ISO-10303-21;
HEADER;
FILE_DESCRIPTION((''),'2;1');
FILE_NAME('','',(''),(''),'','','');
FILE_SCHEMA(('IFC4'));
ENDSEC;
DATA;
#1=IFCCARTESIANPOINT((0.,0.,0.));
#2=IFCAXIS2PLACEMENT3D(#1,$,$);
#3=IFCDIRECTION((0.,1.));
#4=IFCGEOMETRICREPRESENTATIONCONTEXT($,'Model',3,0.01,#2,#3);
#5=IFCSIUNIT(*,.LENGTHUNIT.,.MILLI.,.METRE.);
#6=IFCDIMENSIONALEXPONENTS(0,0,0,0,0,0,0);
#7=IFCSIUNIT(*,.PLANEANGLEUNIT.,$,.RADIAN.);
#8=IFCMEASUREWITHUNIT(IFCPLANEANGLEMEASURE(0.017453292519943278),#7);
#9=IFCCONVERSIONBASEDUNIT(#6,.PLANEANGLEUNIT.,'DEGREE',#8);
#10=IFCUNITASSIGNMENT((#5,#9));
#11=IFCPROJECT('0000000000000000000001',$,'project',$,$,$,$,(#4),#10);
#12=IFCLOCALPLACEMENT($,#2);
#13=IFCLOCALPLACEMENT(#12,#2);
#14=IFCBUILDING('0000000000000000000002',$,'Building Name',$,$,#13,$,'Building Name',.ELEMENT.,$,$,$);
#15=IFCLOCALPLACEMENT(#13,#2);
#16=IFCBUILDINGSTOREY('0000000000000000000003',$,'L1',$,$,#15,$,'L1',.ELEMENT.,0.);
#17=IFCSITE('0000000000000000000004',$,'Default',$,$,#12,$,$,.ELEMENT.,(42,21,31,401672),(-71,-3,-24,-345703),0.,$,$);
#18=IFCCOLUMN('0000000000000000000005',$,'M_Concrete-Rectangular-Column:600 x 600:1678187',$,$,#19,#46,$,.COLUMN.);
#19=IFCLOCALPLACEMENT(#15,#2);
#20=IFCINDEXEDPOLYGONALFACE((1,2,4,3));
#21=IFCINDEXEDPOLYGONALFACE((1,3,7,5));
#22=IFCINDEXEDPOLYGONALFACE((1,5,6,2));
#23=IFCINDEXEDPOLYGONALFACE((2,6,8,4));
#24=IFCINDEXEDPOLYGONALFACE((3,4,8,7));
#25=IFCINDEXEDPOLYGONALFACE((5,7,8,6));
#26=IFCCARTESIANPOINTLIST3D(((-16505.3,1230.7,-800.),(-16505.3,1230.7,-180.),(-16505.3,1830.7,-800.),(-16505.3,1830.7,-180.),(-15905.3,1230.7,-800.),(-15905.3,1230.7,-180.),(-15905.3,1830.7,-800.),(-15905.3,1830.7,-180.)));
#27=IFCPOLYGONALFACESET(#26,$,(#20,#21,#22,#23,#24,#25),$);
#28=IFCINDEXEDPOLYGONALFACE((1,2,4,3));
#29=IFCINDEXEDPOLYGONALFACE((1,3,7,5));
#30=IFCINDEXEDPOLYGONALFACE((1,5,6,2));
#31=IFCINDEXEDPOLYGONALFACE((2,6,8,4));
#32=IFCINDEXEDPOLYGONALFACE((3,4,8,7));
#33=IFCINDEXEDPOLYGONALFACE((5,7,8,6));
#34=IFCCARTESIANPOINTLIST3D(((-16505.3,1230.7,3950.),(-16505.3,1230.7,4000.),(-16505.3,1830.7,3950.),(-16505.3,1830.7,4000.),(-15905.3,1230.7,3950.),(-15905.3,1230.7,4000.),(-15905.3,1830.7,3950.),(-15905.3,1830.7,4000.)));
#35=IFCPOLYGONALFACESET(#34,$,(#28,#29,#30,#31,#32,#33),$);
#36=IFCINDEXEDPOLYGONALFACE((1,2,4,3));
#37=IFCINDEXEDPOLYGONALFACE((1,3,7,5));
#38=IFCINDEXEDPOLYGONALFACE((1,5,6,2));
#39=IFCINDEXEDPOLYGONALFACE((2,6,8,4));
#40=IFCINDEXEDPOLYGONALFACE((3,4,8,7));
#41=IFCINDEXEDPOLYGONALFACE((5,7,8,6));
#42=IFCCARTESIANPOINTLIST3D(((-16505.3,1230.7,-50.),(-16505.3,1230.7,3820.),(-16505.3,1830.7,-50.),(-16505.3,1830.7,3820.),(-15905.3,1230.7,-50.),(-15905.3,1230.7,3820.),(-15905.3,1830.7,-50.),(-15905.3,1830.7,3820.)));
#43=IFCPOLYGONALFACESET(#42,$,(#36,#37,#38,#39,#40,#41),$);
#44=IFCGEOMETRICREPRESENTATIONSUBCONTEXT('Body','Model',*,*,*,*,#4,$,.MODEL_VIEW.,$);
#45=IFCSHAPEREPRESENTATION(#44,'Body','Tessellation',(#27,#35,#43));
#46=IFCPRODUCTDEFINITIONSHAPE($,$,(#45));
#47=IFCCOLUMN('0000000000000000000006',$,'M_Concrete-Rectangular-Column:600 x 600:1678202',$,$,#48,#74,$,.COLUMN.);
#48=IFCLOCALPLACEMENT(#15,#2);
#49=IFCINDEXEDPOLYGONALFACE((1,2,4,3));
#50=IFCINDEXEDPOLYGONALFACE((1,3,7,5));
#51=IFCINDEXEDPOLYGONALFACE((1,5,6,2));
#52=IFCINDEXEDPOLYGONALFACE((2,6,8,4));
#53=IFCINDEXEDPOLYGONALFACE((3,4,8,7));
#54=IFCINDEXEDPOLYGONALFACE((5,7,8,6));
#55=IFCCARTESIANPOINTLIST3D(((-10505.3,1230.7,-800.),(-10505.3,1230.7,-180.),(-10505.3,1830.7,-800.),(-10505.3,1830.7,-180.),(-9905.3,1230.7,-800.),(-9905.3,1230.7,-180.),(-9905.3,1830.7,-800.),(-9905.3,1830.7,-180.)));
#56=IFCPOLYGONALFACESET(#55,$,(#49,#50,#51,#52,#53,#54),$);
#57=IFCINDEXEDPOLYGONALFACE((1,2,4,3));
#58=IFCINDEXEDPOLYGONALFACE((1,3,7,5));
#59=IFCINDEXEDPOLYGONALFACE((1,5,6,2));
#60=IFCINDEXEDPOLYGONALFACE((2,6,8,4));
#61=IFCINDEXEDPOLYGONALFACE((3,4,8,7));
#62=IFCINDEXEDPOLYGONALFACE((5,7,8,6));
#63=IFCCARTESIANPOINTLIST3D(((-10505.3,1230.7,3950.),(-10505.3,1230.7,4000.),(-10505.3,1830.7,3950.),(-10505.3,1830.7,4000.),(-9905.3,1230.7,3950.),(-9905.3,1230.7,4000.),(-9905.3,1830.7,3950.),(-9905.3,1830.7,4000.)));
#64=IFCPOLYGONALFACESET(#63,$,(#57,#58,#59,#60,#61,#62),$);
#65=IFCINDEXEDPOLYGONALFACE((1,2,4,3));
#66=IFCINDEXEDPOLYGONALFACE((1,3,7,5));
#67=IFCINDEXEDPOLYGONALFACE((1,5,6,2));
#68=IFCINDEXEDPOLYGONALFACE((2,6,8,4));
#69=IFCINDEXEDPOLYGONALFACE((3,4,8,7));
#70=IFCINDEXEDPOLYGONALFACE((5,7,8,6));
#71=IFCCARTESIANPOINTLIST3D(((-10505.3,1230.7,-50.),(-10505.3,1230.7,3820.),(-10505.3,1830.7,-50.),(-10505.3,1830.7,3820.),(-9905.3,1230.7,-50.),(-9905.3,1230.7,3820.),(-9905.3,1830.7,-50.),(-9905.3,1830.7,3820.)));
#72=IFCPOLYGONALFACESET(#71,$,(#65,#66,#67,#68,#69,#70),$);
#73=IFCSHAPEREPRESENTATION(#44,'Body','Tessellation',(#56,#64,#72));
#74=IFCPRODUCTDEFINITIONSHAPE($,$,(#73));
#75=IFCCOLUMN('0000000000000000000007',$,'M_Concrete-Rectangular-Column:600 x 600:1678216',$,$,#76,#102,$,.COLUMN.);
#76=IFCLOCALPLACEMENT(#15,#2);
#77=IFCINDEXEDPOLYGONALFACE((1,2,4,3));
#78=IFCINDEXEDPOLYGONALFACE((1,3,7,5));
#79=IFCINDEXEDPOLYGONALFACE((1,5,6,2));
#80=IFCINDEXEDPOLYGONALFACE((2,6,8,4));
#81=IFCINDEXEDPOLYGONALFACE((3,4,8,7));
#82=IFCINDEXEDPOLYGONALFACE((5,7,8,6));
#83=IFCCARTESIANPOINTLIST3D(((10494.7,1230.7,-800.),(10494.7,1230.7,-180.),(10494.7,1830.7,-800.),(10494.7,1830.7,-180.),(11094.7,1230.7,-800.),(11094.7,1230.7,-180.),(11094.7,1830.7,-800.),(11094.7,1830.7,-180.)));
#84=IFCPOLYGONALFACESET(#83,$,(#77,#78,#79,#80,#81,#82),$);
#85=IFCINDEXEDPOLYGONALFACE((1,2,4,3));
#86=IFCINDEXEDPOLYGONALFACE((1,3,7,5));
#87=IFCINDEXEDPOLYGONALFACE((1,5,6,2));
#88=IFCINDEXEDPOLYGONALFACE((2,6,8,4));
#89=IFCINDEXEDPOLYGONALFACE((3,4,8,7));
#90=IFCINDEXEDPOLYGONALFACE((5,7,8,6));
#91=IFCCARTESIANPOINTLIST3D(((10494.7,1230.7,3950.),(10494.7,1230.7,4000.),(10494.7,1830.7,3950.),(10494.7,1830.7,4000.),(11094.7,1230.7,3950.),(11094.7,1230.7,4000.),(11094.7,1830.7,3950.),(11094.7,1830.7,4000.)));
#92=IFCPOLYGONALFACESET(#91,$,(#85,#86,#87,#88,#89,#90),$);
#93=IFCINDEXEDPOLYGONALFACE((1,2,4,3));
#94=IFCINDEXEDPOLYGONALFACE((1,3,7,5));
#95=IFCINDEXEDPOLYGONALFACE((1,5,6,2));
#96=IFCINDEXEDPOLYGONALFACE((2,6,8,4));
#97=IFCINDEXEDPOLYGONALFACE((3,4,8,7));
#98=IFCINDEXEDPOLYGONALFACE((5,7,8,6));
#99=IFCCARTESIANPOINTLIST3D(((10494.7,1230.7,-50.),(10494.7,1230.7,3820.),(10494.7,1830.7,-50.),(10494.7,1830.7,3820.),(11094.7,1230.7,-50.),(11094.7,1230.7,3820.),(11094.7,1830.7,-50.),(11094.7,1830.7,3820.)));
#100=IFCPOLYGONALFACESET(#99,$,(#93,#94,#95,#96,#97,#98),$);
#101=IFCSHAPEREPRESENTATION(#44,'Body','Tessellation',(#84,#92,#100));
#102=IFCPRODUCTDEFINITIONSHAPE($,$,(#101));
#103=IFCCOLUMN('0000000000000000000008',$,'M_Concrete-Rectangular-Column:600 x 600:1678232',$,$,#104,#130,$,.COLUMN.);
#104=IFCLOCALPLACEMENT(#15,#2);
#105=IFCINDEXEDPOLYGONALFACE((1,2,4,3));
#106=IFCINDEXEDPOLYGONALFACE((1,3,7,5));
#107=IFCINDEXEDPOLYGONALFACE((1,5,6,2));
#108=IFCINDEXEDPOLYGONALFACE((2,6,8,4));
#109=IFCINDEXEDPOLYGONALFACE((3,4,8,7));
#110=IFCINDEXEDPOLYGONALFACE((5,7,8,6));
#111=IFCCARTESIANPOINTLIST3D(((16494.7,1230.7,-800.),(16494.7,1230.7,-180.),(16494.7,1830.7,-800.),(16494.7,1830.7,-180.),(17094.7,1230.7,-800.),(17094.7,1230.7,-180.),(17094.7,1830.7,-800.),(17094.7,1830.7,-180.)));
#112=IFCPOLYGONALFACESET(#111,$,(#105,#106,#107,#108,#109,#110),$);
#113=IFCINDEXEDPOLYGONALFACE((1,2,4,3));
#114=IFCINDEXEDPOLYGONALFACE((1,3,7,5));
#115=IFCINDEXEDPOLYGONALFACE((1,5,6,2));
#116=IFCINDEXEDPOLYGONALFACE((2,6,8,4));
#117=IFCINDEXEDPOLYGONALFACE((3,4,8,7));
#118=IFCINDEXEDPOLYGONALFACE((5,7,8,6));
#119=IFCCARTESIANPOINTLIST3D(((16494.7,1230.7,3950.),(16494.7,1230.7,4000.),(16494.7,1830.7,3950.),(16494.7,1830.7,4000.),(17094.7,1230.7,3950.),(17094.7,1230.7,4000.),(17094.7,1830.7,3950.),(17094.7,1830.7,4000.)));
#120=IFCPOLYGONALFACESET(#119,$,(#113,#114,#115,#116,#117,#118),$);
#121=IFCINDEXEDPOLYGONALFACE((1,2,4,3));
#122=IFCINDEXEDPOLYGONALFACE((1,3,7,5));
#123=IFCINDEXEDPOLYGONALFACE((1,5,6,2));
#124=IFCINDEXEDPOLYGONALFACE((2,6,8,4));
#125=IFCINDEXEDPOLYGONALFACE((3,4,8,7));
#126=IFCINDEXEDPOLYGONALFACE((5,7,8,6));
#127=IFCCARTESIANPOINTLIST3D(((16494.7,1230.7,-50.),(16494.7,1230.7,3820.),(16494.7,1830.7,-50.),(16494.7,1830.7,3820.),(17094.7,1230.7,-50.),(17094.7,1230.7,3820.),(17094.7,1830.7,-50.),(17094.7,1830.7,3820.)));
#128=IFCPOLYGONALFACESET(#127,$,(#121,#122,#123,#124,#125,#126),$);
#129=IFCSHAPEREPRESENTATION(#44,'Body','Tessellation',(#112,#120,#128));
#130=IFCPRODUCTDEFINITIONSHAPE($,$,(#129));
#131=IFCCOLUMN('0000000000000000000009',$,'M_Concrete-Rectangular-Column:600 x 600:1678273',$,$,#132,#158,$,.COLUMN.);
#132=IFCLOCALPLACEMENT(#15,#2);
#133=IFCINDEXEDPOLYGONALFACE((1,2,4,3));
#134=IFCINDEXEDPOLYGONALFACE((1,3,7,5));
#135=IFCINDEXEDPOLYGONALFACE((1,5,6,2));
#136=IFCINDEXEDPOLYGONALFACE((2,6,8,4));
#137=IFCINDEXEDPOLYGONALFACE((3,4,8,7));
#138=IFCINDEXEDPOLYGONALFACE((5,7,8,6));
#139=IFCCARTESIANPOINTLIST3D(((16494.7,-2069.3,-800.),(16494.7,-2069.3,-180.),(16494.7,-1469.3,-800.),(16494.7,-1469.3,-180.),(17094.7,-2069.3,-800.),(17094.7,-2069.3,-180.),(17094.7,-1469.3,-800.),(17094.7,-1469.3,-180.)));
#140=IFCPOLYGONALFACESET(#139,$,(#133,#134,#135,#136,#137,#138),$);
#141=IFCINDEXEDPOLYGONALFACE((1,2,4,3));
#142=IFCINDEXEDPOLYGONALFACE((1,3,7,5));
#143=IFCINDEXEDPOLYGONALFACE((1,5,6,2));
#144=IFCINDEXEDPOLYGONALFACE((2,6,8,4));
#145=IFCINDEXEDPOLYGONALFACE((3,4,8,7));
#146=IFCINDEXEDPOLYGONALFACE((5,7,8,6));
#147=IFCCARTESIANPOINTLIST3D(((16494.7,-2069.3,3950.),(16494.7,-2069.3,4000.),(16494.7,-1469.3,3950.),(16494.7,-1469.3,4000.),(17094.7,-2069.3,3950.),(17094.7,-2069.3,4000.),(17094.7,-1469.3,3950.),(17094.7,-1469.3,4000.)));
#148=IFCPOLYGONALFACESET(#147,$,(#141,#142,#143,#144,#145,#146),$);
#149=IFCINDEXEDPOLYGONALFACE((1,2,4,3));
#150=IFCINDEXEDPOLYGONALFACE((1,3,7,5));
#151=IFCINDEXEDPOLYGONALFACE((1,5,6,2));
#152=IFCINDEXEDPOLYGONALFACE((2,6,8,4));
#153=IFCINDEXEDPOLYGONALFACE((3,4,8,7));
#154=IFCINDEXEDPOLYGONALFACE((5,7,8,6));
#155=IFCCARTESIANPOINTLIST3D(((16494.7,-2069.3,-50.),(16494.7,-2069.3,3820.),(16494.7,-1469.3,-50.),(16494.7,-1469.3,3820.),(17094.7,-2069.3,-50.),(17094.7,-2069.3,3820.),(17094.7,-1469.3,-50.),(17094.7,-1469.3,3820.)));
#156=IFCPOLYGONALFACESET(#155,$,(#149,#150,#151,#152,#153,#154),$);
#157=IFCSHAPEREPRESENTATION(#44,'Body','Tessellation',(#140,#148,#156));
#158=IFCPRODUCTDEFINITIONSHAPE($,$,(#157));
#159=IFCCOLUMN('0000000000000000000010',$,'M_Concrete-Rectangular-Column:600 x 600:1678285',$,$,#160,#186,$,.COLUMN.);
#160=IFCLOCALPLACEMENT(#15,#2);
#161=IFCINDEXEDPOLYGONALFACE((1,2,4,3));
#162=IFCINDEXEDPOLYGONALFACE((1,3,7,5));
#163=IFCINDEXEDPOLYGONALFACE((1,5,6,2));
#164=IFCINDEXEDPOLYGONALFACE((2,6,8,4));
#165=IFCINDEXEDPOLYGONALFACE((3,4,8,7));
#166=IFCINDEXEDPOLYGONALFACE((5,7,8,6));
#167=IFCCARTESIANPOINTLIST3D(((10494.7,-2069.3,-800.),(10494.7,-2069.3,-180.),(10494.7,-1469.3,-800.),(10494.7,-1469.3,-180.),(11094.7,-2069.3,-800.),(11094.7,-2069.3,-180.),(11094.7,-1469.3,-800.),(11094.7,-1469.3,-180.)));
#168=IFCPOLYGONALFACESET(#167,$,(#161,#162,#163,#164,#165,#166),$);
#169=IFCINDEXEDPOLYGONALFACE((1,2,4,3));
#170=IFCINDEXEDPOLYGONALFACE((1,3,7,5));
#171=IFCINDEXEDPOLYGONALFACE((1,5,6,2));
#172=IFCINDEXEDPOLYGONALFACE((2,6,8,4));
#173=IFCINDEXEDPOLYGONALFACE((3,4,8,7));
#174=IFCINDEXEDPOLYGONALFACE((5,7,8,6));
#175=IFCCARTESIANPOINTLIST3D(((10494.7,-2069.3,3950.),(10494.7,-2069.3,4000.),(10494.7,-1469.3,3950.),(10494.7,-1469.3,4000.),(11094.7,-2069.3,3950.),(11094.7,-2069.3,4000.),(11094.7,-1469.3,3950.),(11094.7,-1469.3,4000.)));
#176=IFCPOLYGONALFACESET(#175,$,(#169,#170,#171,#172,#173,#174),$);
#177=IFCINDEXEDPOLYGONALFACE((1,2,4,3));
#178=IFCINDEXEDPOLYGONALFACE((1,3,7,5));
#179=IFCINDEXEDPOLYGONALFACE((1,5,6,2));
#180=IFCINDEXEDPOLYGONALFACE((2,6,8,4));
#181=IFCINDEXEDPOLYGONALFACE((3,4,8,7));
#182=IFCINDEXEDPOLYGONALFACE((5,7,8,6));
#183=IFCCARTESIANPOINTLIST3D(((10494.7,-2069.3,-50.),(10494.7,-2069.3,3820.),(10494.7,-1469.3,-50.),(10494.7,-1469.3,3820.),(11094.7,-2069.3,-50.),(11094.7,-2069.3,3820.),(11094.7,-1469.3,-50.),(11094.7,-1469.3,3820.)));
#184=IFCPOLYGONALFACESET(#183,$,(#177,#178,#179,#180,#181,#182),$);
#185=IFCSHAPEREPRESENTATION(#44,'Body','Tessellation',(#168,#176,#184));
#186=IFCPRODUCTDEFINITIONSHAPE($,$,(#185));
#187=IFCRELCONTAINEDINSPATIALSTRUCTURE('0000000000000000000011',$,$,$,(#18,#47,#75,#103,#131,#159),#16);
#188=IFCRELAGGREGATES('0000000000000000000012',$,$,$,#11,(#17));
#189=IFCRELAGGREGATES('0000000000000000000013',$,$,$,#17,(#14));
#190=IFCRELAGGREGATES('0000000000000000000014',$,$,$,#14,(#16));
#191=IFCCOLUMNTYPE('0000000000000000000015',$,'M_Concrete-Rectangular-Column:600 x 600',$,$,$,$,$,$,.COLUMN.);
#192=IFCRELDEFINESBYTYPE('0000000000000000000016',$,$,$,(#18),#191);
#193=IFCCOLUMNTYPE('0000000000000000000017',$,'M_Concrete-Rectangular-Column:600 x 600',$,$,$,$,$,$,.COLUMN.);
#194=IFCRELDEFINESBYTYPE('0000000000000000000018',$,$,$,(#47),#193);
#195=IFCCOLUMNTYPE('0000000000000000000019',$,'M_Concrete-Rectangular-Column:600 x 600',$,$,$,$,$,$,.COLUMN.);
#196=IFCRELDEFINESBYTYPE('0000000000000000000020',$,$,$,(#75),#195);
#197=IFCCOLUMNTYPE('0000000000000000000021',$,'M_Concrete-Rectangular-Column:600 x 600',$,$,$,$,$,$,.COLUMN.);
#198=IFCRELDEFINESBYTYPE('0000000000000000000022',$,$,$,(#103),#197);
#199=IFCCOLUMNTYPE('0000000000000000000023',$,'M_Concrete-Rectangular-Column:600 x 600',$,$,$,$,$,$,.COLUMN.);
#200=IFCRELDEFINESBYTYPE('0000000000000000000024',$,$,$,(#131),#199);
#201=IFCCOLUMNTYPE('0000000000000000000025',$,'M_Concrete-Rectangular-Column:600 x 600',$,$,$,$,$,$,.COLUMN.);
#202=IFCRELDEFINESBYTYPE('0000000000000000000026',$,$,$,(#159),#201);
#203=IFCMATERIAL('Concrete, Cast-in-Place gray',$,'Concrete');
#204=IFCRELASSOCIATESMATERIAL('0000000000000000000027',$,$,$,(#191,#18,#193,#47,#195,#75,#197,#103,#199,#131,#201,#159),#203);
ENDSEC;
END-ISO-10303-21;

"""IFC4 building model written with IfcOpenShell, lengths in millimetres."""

from ifc_helpers import new_model, entity, si_unit, converted_unit, direction, frame, origin, place, context, subcontext, project, spatial, indexed_curve, outline, extrude, source, transform, mapped, material, type_object, type_shapes, element, save


model = new_model("IFC4")

# Units and contexts
model_context = context("Model", 3, precision=0.01, world=origin(), true_north=direction((0.0, 1.0)))
body_context = subcontext(model_context, "Body", "Model", "MODEL_VIEW")
ifc_project = project(units=[si_unit("LENGTHUNIT", "METRE", prefix="MILLI"), converted_unit("PLANEANGLEUNIT", "DEGREE", entity("IfcPlaneAngleMeasure", 0.017453292519943278), si_unit("PLANEANGLEUNIT", "RADIAN"), dimensions=[0, 0, 0, 0, 0, 0, 0])], contexts=[model_context])

# Site, building, storey
site_placement = place(None, origin())
site = spatial("IfcSite", under=ifc_project, at=site_placement, Name="Default", CompositionType="ELEMENT", RefLatitude=(42, 21, 31, 401672), RefLongitude=(-71, -3, -24, -345703), RefElevation=0.0)
building_placement = place(site_placement, origin())
building = spatial("IfcBuilding", under=site, at=building_placement, Name="Building Name", LongName="Building Name", CompositionType="ELEMENT")
storey_placement = place(building_placement, origin())
storey = spatial("IfcBuildingStorey", under=building, at=storey_placement, Name="L1", LongName="L1", CompositionType="ELEMENT", Elevation=0.0)

# Columns
ifc_material = material(Name="Concrete, Cast-in-Place gray", Category="Concrete")
column_type_1 = type_object("IfcColumnType", Name="M_Concrete-Rectangular-Column:600 x 600", PredefinedType="COLUMN", material=ifc_material)
shared_shape_1 = source(origin(), body_context, "Body", "SweptSolid", [
    extrude(outline(indexed_curve([(-300.0, -300.0), (300.0, -300.0), (300.0, 300.0), (-300.0, 300.0), (-300.0, -300.0)], self_intersect=False)), frame((-16205.3, 1530.7, -800.0), z_axis=(0.0, 0.0, 1.0), x_axis=(-1.0, 0.0, 0.0)), (0.0, 0.0, 1.0), 620.0),
    extrude(outline(indexed_curve([(-300.0, -300.0), (300.0, -300.0), (300.0, 300.0), (-300.0, 300.0), (-300.0, -300.0)], self_intersect=False)), frame((-16205.3, 1530.7, 3950.0)), (0.0, 0.0, 1.0), 50.0),
    extrude(outline(indexed_curve([(-300.0, -300.0), (300.0, -300.0), (300.0, 300.0), (-300.0, 300.0), (-300.0, -300.0)], self_intersect=False)), frame((-16205.3, 1530.7, -50.0)), (0.0, 0.0, 1.0), 3870.0),
])
type_shapes(column_type_1, [shared_shape_1])
column_1_placement = place(storey_placement, origin())
element("IfcColumn", 1, at=column_1_placement, inside=storey, type_object=column_type_1, material=ifc_material, Name="M_Concrete-Rectangular-Column:600 x 600:1678187", PredefinedType="COLUMN", context=body_context, shape_type="MappedRepresentation", body=[
    mapped(shared_shape_1, transform((0.0, 0.0, 0.0), scale=1.0)),
])
column_type_2 = type_object("IfcColumnType", Name="M_Concrete-Rectangular-Column:600 x 600", PredefinedType="COLUMN", material=ifc_material)
shared_shape_2 = source(origin(), body_context, "Body", "SweptSolid", [
    extrude(outline(indexed_curve([(-300.0, -300.0), (300.0, -300.0), (300.0, 300.0), (-300.0, 300.0), (-300.0, -300.0)], self_intersect=False)), frame((-10205.3, 1530.7, -800.0), z_axis=(0.0, 0.0, 1.0), x_axis=(-1.0, 0.0, 0.0)), (0.0, 0.0, 1.0), 620.0),
    extrude(outline(indexed_curve([(-300.0, -300.0), (300.0, -300.0), (300.0, 300.0), (-300.0, 300.0), (-300.0, -300.0)], self_intersect=False)), frame((-10205.3, 1530.7, 3950.0)), (0.0, 0.0, 1.0), 50.0),
    extrude(outline(indexed_curve([(-300.0, -300.0), (300.0, -300.0), (300.0, 300.0), (-300.0, 300.0), (-300.0, -300.0)], self_intersect=False)), frame((-10205.3, 1530.7, -50.0)), (0.0, 0.0, 1.0), 3870.0),
])
type_shapes(column_type_2, [shared_shape_2])
column_2_placement = place(storey_placement, origin())
element("IfcColumn", 2, at=column_2_placement, inside=storey, type_object=column_type_2, material=ifc_material, Name="M_Concrete-Rectangular-Column:600 x 600:1678202", PredefinedType="COLUMN", context=body_context, shape_type="MappedRepresentation", body=[
    mapped(shared_shape_2, transform((0.0, 0.0, 0.0), scale=1.0)),
])
column_type_3 = type_object("IfcColumnType", Name="M_Concrete-Rectangular-Column:600 x 600", PredefinedType="COLUMN", material=ifc_material)
shared_shape_3 = source(origin(), body_context, "Body", "SweptSolid", [
    extrude(outline(indexed_curve([(-300.0, -300.0), (300.0, -300.0), (300.0, 300.0), (-300.0, 300.0), (-300.0, -300.0)], self_intersect=False)), frame((10794.7, 1530.7, -800.0), z_axis=(0.0, 0.0, 1.0), x_axis=(-1.0, 0.0, 0.0)), (0.0, 0.0, 1.0), 620.0),
    extrude(outline(indexed_curve([(-300.0, -300.0), (300.0, -300.0), (300.0, 300.0), (-300.0, 300.0), (-300.0, -300.0)], self_intersect=False)), frame((10794.7, 1530.7, 3950.0)), (0.0, 0.0, 1.0), 50.0),
    extrude(outline(indexed_curve([(-300.0, -300.0), (300.0, -300.0), (300.0, 300.0), (-300.0, 300.0), (-300.0, -300.0)], self_intersect=False)), frame((10794.7, 1530.7, -50.0)), (0.0, 0.0, 1.0), 3870.0),
])
type_shapes(column_type_3, [shared_shape_3])
column_3_placement = place(storey_placement, origin())
element("IfcColumn", 3, at=column_3_placement, inside=storey, type_object=column_type_3, material=ifc_material, Name="M_Concrete-Rectangular-Column:600 x 600:1678216", PredefinedType="COLUMN", context=body_context, shape_type="MappedRepresentation", body=[
    mapped(shared_shape_3, transform((0.0, 0.0, 0.0), scale=1.0)),
])
column_type_4 = type_object("IfcColumnType", Name="M_Concrete-Rectangular-Column:600 x 600", PredefinedType="COLUMN", material=ifc_material)
shared_shape_4 = source(origin(), body_context, "Body", "SweptSolid", [
    extrude(outline(indexed_curve([(-300.0, -300.0), (300.0, -300.0), (300.0, 300.0), (-300.0, 300.0), (-300.0, -300.0)], self_intersect=False)), frame((16794.7, 1530.7, -800.0), z_axis=(0.0, 0.0, 1.0), x_axis=(-1.0, 0.0, 0.0)), (0.0, 0.0, 1.0), 620.0),
    extrude(outline(indexed_curve([(-300.0, -300.0), (300.0, -300.0), (300.0, 300.0), (-300.0, 300.0), (-300.0, -300.0)], self_intersect=False)), frame((16794.7, 1530.7, 3950.0)), (0.0, 0.0, 1.0), 50.0),
    extrude(outline(indexed_curve([(-300.0, -300.0), (300.0, -300.0), (300.0, 300.0), (-300.0, 300.0), (-300.0, -300.0)], self_intersect=False)), frame((16794.7, 1530.7, -50.0), z_axis=(0.0, 0.0, 1.0), x_axis=(0.0, -1.0, 0.0)), (0.0, 0.0, 1.0), 3870.0),
])
type_shapes(column_type_4, [shared_shape_4])
column_4_placement = place(storey_placement, origin())
element("IfcColumn", 4, at=column_4_placement, inside=storey, type_object=column_type_4, material=ifc_material, Name="M_Concrete-Rectangular-Column:600 x 600:1678232", PredefinedType="COLUMN", context=body_context, shape_type="MappedRepresentation", body=[
    mapped(shared_shape_4, transform((0.0, 0.0, 0.0), scale=1.0)),
])
column_type_5 = type_object("IfcColumnType", Name="M_Concrete-Rectangular-Column:600 x 600", PredefinedType="COLUMN", material=ifc_material)
shared_shape_5 = source(origin(), body_context, "Body", "SweptSolid", [
    extrude(outline(indexed_curve([(-300.0, -300.0), (300.0, -300.0), (300.0, 300.0), (-300.0, 300.0), (-300.0, -300.0)], self_intersect=False)), frame((16794.7, -1769.3, -800.0), z_axis=(0.0, 0.0, 1.0), x_axis=(-1.0, 0.0, 0.0)), (0.0, 0.0, 1.0), 620.0),
    extrude(outline(indexed_curve([(-300.0, -300.0), (300.0, -300.0), (300.0, 300.0), (-300.0, 300.0), (-300.0, -300.0)], self_intersect=False)), frame((16794.7, -1769.3, 3950.0)), (0.0, 0.0, 1.0), 50.0),
    extrude(outline(indexed_curve([(-300.0, -300.0), (300.0, -300.0), (300.0, 300.0), (-300.0, 300.0), (-300.0, -300.0)], self_intersect=False)), frame((16794.7, -1769.3, -50.0), z_axis=(0.0, 0.0, 1.0), x_axis=(0.0, 1.0, 0.0)), (0.0, 0.0, 1.0), 3870.0),
])
type_shapes(column_type_5, [shared_shape_5])
column_5_placement = place(storey_placement, origin())
element("IfcColumn", 5, at=column_5_placement, inside=storey, type_object=column_type_5, material=ifc_material, Name="M_Concrete-Rectangular-Column:600 x 600:1678273", PredefinedType="COLUMN", context=body_context, shape_type="MappedRepresentation", body=[
    mapped(shared_shape_5, transform((0.0, 0.0, 0.0), scale=1.0)),
])
column_type_6 = type_object("IfcColumnType", Name="M_Concrete-Rectangular-Column:600 x 600", PredefinedType="COLUMN", material=ifc_material)
shared_shape_6 = source(origin(), body_context, "Body", "SweptSolid", [
    extrude(outline(indexed_curve([(-300.0, -300.0), (300.0, -300.0), (300.0, 300.0), (-300.0, 300.0), (-300.0, -300.0)], self_intersect=False)), frame((10794.7, -1769.3, -800.0), z_axis=(0.0, 0.0, 1.0), x_axis=(-1.0, 0.0, 0.0)), (0.0, 0.0, 1.0), 620.0),
    extrude(outline(indexed_curve([(-300.0, -300.0), (300.0, -300.0), (300.0, 300.0), (-300.0, 300.0), (-300.0, -300.0)], self_intersect=False)), frame((10794.7, -1769.3, 3950.0)), (0.0, 0.0, 1.0), 50.0),
    extrude(outline(indexed_curve([(-300.0, -300.0), (300.0, -300.0), (300.0, 300.0), (-300.0, 300.0), (-300.0, -300.0)], self_intersect=False)), frame((10794.7, -1769.3, -50.0)), (0.0, 0.0, 1.0), 3870.0),
])
type_shapes(column_type_6, [shared_shape_6])
column_6_placement = place(storey_placement, origin())
element("IfcColumn", 6, at=column_6_placement, inside=storey, type_object=column_type_6, material=ifc_material, Name="M_Concrete-Rectangular-Column:600 x 600:1678285", PredefinedType="COLUMN", context=body_context, shape_type="MappedRepresentation", body=[
    mapped(shared_shape_6, transform((0.0, 0.0, 0.0), scale=1.0)),
])

save(model, "model.ifc")
